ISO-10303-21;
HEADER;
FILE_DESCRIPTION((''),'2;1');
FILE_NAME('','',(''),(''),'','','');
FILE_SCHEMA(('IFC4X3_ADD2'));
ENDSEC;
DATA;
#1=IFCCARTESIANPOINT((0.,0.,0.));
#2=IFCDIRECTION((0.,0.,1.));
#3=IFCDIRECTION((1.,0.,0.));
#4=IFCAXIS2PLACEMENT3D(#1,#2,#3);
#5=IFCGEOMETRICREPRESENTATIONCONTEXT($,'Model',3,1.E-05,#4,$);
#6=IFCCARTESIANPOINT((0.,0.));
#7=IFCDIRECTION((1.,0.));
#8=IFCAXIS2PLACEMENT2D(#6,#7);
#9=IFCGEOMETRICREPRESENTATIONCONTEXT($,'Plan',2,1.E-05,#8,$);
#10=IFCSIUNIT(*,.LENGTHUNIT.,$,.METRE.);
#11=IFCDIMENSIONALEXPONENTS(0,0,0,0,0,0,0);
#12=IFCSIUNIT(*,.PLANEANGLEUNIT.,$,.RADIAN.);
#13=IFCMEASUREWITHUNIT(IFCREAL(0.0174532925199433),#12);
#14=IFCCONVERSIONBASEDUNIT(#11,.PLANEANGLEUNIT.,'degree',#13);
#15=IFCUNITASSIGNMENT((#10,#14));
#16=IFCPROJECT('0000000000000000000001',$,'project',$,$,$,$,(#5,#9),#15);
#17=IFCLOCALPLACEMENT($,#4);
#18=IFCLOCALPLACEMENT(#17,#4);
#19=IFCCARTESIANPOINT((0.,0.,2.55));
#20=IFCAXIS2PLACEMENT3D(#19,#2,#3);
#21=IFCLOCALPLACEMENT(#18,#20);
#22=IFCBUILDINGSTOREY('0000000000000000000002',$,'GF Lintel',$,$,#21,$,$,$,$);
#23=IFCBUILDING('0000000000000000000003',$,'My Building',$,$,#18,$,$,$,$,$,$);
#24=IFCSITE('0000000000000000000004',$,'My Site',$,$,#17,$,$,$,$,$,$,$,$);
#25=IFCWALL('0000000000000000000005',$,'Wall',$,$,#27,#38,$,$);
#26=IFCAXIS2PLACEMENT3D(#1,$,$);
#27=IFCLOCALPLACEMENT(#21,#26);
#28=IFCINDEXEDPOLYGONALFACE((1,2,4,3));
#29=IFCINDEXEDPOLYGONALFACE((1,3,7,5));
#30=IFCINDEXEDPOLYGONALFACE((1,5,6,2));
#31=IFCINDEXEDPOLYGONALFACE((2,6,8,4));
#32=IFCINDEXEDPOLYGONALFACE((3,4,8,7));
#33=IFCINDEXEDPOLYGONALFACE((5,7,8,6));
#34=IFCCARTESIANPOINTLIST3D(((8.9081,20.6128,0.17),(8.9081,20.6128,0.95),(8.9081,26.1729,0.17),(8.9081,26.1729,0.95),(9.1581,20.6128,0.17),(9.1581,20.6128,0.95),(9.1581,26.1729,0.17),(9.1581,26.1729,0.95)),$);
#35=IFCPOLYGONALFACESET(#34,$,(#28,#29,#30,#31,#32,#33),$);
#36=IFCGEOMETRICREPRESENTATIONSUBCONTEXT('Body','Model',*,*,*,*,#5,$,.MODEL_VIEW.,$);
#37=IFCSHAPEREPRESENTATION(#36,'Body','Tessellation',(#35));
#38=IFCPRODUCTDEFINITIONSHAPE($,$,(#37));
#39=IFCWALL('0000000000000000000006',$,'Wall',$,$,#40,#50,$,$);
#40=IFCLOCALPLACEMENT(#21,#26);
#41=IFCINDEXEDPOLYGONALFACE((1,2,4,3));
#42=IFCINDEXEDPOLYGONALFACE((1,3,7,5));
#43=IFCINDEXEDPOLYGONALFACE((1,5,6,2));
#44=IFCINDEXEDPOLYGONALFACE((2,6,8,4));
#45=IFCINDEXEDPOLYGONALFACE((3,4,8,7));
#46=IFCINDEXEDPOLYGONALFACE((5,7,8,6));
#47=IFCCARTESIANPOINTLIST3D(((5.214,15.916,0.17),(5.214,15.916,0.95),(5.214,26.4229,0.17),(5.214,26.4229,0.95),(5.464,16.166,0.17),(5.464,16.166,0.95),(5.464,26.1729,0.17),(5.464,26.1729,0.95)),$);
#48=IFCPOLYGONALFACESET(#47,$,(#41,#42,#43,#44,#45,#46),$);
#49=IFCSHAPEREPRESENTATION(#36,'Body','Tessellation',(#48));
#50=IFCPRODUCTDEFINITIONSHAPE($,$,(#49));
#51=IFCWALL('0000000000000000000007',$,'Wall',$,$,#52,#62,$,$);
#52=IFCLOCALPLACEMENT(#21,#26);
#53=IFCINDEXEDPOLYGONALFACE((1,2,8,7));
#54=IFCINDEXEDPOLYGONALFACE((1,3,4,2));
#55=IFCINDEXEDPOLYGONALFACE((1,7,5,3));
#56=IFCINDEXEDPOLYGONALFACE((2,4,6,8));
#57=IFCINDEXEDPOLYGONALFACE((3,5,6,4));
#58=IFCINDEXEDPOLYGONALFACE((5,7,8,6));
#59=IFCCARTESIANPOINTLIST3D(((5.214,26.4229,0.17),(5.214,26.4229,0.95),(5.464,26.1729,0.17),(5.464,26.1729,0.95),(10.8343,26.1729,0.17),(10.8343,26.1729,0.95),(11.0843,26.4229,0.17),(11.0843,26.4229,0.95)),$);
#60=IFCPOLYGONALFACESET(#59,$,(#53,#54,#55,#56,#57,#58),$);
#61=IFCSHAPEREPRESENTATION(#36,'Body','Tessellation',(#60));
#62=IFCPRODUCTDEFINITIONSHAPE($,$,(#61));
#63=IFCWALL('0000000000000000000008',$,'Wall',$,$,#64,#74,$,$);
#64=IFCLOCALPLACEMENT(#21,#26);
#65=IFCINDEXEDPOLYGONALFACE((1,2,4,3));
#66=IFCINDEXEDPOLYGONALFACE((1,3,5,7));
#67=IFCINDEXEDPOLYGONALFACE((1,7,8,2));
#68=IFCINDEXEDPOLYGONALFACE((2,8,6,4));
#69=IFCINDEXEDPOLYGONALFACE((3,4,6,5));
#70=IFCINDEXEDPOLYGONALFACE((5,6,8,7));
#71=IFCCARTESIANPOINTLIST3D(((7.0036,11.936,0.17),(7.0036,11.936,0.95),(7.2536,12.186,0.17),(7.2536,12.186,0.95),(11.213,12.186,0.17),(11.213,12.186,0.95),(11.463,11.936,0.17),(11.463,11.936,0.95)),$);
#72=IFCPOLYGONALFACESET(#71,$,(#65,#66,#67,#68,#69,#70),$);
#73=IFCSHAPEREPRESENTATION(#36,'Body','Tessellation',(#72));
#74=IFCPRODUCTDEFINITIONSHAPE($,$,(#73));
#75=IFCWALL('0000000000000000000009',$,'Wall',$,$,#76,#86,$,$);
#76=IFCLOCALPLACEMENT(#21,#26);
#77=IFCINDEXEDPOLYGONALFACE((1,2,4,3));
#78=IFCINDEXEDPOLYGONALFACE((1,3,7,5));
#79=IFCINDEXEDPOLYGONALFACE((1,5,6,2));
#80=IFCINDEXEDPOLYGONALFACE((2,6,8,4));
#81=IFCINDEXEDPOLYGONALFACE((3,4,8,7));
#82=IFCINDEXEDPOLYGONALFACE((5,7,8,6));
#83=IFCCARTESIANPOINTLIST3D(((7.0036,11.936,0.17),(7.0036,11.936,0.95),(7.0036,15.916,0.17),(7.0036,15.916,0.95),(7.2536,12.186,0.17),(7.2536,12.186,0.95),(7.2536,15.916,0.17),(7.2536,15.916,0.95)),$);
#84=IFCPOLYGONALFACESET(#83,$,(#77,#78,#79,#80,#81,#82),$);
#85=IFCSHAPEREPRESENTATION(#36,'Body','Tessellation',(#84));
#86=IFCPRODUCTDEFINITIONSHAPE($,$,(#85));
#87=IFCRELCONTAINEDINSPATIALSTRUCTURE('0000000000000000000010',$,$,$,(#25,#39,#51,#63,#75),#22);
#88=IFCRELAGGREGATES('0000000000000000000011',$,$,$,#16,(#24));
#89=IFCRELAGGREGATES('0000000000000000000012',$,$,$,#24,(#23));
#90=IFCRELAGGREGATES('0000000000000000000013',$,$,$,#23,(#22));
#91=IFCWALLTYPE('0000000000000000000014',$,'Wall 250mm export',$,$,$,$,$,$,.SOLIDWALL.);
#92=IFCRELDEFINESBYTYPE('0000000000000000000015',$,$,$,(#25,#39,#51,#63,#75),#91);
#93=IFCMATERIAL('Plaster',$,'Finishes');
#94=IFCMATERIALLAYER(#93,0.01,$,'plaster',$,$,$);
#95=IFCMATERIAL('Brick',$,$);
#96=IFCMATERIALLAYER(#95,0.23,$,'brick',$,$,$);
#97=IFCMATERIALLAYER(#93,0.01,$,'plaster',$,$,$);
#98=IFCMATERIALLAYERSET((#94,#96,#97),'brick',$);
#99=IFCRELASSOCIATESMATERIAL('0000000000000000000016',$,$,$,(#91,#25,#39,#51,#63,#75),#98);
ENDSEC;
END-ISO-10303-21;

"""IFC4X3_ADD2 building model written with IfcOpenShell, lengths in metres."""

from ifc_helpers import new_model, entity, si_unit, converted_unit, frame, origin_with_axes, origin_2d_with_axis, place, context, subcontext, project, spatial, line, indexed_curve, outline, extrude, material, layer, layer_set, layer_usage, type_object, element, save


model = new_model("IFC4X3_ADD2")

# Units and contexts
model_context = context("Model", 3, precision=1e-05, world=origin_with_axes())
plan_context = context("Plan", 2, precision=1e-05, world=origin_2d_with_axis())
body_context = subcontext(model_context, "Body", "Model", "MODEL_VIEW")
ifc_project = project(units=[si_unit("LENGTHUNIT", "METRE"), converted_unit("PLANEANGLEUNIT", "degree", entity("IfcReal", 0.0174532925199433), si_unit("PLANEANGLEUNIT", "RADIAN"), dimensions=[0, 0, 0, 0, 0, 0, 0])], contexts=[model_context, plan_context])

# Site, building, storey
site_placement = place(None, origin_with_axes())
site = spatial("IfcSite", under=ifc_project, at=site_placement, Name="My Site")
building_placement = place(site_placement, origin_with_axes())
building = spatial("IfcBuilding", under=site, at=building_placement, Name="My Building")
storey_placement = place(building_placement, frame((0.0, 0.0, 2.55), z_axis=(0.0, 0.0, 1.0), x_axis=(1.0, 0.0, 0.0)))
storey = spatial("IfcBuildingStorey", under=building, at=storey_placement, Name="GF Lintel")

# Walls
ifc_material_1 = material(Name="Plaster", Category="Finishes")
ifc_layer_1 = layer(ifc_material_1, 0.01, Name="plaster")
ifc_material_2 = material(Name="Brick")
ifc_layer_2 = layer(ifc_material_2, 0.23, Name="brick")
ifc_layer_3 = layer(ifc_material_1, 0.01, Name="plaster")
ifc_layer_set_1 = layer_set([ifc_layer_1, ifc_layer_2, ifc_layer_3], Name="brick")
wall_type_1 = type_object("IfcWallType", Name="Wall 250mm export", PredefinedType="SOLIDWALL", material=ifc_layer_set_1)
ifc_layer_usage_1 = layer_usage(ifc_layer_set_1, "AXIS2", "POSITIVE", 0.0)
wall_1_placement = place(storey_placement, frame((9.1581, 20.6128, 0.17), z_axis=(0.0, 0.0, 1.0), x_axis=(0.0, 1.0, 0.0)))
element("IfcWall", 1, at=wall_1_placement, inside=storey, type_object=wall_type_1, material=ifc_layer_usage_1, Name="Wall", context=body_context, shape_type="SweptSolid", body=[
    extrude(outline(indexed_curve([(0.0, 0.0), (0.0, 0.25), (5.5601, 0.25), (5.5601, 0.0)], segments=[line(1, 2, 3, 4, 1)])), origin_with_axes(), (0.0, 0.0, 1.0), 0.78),
])
ifc_layer_usage_2 = layer_usage(ifc_layer_set_1, "AXIS2", "POSITIVE", 0.0)
wall_2_placement = place(storey_placement, frame((5.464, 15.916, 0.17), z_axis=(0.0, 0.0, 1.0), x_axis=(0.0, 1.0, 0.0)))
element("IfcWall", 2, at=wall_2_placement, inside=storey, type_object=wall_type_1, material=ifc_layer_usage_2, Name="Wall", context=body_context, shape_type="SweptSolid", body=[
    extrude(outline(indexed_curve([(0.25, 0.0), (0.0, 0.25), (10.5069, 0.25), (10.2569, 0.0)], segments=[line(1, 2, 3, 4, 1)])), origin_with_axes(), (0.0, 0.0, 1.0), 0.78),
])
ifc_layer_usage_3 = layer_usage(ifc_layer_set_1, "AXIS2", "POSITIVE", 0.0)
wall_3_placement = place(storey_placement, frame((5.464, 26.1729, 0.17), z_axis=(0.0, 0.0, 1.0), x_axis=(1.0, 0.0, 0.0)))
element("IfcWall", 3, at=wall_3_placement, inside=storey, type_object=wall_type_1, material=ifc_layer_usage_3, Name="Wall", context=body_context, shape_type="SweptSolid", body=[
    extrude(outline(indexed_curve([(0.0, 0.0), (-0.25, 0.25), (5.6203, 0.25), (5.3703, 0.0)], segments=[line(1, 2, 3, 4, 1)])), origin_with_axes(), (0.0, 0.0, 1.0), 0.78),
])
ifc_layer_usage_4 = layer_usage(ifc_layer_set_1, "AXIS2", "POSITIVE", 0.0)
wall_4_placement = place(storey_placement, frame((7.2536, 11.936, 0.17), z_axis=(0.0, 0.0, 1.0), x_axis=(1.0, 0.0, 0.0)))
element("IfcWall", 4, at=wall_4_placement, inside=storey, type_object=wall_type_1, material=ifc_layer_usage_4, Name="Wall", context=body_context, shape_type="SweptSolid", body=[
    extrude(outline(indexed_curve([(-0.25, 0.0), (0.0, 0.25), (3.9594, 0.25), (4.2094, 0.0)], segments=[line(1, 2, 3, 4, 1)])), origin_with_axes(), (0.0, 0.0, 1.0), 0.78),
])
ifc_layer_usage_5 = layer_usage(ifc_layer_set_1, "AXIS2", "POSITIVE", 0.0)
wall_5_placement = place(storey_placement, frame((7.2536, 11.936, 0.17), z_axis=(0.0, 0.0, 1.0), x_axis=(0.0, 1.0, 0.0)))
element("IfcWall", 5, at=wall_5_placement, inside=storey, type_object=wall_type_1, material=ifc_layer_usage_5, Name="Wall", context=body_context, shape_type="SweptSolid", body=[
    extrude(outline(indexed_curve([(0.25, 0.0), (0.0, 0.25), (3.98, 0.25), (3.98, 0.0)], segments=[line(1, 2, 3, 4, 1)])), origin_with_axes(), (0.0, 0.0, 1.0), 0.78),
])

save(model, "model.ifc")
